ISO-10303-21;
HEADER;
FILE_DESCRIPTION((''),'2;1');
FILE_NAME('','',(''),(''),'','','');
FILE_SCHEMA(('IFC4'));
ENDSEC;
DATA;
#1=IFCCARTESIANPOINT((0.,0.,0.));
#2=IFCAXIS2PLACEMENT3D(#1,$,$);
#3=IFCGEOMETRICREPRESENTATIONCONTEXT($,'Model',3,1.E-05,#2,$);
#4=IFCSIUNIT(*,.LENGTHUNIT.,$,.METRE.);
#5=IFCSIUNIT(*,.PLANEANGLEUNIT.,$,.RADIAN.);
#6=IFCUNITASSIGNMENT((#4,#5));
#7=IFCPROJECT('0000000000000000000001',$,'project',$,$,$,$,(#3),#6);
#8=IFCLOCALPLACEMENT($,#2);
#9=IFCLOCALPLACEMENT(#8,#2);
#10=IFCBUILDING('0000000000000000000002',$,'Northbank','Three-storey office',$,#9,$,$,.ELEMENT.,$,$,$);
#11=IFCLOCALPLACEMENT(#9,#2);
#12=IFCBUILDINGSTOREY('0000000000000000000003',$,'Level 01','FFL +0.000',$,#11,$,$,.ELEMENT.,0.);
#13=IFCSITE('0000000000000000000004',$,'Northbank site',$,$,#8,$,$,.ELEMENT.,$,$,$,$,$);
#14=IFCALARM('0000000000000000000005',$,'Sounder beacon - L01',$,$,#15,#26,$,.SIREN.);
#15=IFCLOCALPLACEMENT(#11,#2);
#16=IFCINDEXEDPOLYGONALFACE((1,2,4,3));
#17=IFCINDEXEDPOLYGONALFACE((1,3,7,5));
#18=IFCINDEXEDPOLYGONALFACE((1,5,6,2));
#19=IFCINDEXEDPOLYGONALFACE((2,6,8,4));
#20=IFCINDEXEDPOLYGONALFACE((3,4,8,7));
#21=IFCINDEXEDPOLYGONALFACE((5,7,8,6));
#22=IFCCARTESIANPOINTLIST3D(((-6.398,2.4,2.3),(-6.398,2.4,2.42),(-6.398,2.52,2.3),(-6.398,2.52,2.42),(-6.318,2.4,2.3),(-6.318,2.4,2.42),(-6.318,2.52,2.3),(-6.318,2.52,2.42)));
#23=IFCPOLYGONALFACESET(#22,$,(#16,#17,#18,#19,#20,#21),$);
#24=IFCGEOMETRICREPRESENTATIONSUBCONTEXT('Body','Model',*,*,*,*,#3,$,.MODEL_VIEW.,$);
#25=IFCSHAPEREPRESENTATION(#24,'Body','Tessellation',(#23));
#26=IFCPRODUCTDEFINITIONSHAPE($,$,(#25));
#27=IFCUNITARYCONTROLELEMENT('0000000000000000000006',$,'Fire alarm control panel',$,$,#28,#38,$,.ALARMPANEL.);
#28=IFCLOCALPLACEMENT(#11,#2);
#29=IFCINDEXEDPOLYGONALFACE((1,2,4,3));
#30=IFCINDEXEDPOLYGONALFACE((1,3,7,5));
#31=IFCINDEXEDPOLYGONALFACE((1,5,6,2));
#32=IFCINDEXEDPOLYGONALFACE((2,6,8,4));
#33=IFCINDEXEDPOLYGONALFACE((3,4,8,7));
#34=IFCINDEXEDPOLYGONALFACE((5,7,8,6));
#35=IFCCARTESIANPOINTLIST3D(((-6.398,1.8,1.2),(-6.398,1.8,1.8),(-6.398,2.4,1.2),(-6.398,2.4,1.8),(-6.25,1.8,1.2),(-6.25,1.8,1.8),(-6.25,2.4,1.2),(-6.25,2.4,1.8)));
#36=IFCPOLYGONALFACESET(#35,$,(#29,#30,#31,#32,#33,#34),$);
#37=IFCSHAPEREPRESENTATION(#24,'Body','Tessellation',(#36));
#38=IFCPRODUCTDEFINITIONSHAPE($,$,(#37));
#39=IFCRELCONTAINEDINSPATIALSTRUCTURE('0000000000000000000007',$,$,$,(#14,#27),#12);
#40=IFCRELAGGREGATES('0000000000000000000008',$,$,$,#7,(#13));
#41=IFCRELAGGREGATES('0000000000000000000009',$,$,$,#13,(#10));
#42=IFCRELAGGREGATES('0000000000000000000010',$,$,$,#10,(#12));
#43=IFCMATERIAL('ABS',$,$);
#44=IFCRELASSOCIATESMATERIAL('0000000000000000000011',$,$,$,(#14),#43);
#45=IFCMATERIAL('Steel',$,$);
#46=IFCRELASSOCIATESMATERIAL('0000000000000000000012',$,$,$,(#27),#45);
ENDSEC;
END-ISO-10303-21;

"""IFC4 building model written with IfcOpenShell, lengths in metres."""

from ifc_helpers import new_model, si_unit, frame, origin, place, context, subcontext, project, spatial, rectangle, extrude, material, element, save


model = new_model("IFC4")

# Units and contexts
model_context = context("Model", 3, precision=1e-05, world=origin())
body_context = subcontext(model_context, "Body", "Model", "MODEL_VIEW")
ifc_project = project(units=[si_unit("LENGTHUNIT", "METRE"), si_unit("PLANEANGLEUNIT", "RADIAN")], contexts=[model_context])

# Site, building, storey
site_placement = place(None, origin())
site = spatial("IfcSite", under=ifc_project, at=site_placement, Name="Northbank site", CompositionType="ELEMENT")
building_placement = place(site_placement, origin())
building = spatial("IfcBuilding", under=site, at=building_placement, Name="Northbank", Description="Three-storey office", CompositionType="ELEMENT")
storey_placement = place(building_placement, origin())
storey = spatial("IfcBuildingStorey", under=building, at=storey_placement, Name="Level 01", Description="FFL +0.000", CompositionType="ELEMENT", Elevation=0.0)

# Shared definitions
ifc_material_1 = material(Name="ABS")

# Alarm
alarm_1_placement = place(storey_placement, origin())
element("IfcAlarm", 1, at=alarm_1_placement, inside=storey, material=ifc_material_1, Name="Sounder beacon - L01", PredefinedType="SIREN", context=body_context, shape_type="SweptSolid", body=[
    extrude(rectangle(XDim=0.08, YDim=0.12), frame((-6.358, 2.46, 2.3)), (0.0, 0.0, 1.0), 0.12),
])

# Unitary control element
ifc_material_2 = material(Name="Steel")
unitary_control_element_placement = place(storey_placement, origin())
element("IfcUnitaryControlElement", 2, at=unitary_control_element_placement, inside=storey, material=ifc_material_2, Name="Fire alarm control panel", PredefinedType="ALARMPANEL", context=body_context, shape_type="SweptSolid", body=[
    extrude(rectangle(XDim=0.148, YDim=0.6), frame((-6.324, 2.1, 1.2)), (0.0, 0.0, 1.0), 0.6),
])

save(model, "model.ifc")
